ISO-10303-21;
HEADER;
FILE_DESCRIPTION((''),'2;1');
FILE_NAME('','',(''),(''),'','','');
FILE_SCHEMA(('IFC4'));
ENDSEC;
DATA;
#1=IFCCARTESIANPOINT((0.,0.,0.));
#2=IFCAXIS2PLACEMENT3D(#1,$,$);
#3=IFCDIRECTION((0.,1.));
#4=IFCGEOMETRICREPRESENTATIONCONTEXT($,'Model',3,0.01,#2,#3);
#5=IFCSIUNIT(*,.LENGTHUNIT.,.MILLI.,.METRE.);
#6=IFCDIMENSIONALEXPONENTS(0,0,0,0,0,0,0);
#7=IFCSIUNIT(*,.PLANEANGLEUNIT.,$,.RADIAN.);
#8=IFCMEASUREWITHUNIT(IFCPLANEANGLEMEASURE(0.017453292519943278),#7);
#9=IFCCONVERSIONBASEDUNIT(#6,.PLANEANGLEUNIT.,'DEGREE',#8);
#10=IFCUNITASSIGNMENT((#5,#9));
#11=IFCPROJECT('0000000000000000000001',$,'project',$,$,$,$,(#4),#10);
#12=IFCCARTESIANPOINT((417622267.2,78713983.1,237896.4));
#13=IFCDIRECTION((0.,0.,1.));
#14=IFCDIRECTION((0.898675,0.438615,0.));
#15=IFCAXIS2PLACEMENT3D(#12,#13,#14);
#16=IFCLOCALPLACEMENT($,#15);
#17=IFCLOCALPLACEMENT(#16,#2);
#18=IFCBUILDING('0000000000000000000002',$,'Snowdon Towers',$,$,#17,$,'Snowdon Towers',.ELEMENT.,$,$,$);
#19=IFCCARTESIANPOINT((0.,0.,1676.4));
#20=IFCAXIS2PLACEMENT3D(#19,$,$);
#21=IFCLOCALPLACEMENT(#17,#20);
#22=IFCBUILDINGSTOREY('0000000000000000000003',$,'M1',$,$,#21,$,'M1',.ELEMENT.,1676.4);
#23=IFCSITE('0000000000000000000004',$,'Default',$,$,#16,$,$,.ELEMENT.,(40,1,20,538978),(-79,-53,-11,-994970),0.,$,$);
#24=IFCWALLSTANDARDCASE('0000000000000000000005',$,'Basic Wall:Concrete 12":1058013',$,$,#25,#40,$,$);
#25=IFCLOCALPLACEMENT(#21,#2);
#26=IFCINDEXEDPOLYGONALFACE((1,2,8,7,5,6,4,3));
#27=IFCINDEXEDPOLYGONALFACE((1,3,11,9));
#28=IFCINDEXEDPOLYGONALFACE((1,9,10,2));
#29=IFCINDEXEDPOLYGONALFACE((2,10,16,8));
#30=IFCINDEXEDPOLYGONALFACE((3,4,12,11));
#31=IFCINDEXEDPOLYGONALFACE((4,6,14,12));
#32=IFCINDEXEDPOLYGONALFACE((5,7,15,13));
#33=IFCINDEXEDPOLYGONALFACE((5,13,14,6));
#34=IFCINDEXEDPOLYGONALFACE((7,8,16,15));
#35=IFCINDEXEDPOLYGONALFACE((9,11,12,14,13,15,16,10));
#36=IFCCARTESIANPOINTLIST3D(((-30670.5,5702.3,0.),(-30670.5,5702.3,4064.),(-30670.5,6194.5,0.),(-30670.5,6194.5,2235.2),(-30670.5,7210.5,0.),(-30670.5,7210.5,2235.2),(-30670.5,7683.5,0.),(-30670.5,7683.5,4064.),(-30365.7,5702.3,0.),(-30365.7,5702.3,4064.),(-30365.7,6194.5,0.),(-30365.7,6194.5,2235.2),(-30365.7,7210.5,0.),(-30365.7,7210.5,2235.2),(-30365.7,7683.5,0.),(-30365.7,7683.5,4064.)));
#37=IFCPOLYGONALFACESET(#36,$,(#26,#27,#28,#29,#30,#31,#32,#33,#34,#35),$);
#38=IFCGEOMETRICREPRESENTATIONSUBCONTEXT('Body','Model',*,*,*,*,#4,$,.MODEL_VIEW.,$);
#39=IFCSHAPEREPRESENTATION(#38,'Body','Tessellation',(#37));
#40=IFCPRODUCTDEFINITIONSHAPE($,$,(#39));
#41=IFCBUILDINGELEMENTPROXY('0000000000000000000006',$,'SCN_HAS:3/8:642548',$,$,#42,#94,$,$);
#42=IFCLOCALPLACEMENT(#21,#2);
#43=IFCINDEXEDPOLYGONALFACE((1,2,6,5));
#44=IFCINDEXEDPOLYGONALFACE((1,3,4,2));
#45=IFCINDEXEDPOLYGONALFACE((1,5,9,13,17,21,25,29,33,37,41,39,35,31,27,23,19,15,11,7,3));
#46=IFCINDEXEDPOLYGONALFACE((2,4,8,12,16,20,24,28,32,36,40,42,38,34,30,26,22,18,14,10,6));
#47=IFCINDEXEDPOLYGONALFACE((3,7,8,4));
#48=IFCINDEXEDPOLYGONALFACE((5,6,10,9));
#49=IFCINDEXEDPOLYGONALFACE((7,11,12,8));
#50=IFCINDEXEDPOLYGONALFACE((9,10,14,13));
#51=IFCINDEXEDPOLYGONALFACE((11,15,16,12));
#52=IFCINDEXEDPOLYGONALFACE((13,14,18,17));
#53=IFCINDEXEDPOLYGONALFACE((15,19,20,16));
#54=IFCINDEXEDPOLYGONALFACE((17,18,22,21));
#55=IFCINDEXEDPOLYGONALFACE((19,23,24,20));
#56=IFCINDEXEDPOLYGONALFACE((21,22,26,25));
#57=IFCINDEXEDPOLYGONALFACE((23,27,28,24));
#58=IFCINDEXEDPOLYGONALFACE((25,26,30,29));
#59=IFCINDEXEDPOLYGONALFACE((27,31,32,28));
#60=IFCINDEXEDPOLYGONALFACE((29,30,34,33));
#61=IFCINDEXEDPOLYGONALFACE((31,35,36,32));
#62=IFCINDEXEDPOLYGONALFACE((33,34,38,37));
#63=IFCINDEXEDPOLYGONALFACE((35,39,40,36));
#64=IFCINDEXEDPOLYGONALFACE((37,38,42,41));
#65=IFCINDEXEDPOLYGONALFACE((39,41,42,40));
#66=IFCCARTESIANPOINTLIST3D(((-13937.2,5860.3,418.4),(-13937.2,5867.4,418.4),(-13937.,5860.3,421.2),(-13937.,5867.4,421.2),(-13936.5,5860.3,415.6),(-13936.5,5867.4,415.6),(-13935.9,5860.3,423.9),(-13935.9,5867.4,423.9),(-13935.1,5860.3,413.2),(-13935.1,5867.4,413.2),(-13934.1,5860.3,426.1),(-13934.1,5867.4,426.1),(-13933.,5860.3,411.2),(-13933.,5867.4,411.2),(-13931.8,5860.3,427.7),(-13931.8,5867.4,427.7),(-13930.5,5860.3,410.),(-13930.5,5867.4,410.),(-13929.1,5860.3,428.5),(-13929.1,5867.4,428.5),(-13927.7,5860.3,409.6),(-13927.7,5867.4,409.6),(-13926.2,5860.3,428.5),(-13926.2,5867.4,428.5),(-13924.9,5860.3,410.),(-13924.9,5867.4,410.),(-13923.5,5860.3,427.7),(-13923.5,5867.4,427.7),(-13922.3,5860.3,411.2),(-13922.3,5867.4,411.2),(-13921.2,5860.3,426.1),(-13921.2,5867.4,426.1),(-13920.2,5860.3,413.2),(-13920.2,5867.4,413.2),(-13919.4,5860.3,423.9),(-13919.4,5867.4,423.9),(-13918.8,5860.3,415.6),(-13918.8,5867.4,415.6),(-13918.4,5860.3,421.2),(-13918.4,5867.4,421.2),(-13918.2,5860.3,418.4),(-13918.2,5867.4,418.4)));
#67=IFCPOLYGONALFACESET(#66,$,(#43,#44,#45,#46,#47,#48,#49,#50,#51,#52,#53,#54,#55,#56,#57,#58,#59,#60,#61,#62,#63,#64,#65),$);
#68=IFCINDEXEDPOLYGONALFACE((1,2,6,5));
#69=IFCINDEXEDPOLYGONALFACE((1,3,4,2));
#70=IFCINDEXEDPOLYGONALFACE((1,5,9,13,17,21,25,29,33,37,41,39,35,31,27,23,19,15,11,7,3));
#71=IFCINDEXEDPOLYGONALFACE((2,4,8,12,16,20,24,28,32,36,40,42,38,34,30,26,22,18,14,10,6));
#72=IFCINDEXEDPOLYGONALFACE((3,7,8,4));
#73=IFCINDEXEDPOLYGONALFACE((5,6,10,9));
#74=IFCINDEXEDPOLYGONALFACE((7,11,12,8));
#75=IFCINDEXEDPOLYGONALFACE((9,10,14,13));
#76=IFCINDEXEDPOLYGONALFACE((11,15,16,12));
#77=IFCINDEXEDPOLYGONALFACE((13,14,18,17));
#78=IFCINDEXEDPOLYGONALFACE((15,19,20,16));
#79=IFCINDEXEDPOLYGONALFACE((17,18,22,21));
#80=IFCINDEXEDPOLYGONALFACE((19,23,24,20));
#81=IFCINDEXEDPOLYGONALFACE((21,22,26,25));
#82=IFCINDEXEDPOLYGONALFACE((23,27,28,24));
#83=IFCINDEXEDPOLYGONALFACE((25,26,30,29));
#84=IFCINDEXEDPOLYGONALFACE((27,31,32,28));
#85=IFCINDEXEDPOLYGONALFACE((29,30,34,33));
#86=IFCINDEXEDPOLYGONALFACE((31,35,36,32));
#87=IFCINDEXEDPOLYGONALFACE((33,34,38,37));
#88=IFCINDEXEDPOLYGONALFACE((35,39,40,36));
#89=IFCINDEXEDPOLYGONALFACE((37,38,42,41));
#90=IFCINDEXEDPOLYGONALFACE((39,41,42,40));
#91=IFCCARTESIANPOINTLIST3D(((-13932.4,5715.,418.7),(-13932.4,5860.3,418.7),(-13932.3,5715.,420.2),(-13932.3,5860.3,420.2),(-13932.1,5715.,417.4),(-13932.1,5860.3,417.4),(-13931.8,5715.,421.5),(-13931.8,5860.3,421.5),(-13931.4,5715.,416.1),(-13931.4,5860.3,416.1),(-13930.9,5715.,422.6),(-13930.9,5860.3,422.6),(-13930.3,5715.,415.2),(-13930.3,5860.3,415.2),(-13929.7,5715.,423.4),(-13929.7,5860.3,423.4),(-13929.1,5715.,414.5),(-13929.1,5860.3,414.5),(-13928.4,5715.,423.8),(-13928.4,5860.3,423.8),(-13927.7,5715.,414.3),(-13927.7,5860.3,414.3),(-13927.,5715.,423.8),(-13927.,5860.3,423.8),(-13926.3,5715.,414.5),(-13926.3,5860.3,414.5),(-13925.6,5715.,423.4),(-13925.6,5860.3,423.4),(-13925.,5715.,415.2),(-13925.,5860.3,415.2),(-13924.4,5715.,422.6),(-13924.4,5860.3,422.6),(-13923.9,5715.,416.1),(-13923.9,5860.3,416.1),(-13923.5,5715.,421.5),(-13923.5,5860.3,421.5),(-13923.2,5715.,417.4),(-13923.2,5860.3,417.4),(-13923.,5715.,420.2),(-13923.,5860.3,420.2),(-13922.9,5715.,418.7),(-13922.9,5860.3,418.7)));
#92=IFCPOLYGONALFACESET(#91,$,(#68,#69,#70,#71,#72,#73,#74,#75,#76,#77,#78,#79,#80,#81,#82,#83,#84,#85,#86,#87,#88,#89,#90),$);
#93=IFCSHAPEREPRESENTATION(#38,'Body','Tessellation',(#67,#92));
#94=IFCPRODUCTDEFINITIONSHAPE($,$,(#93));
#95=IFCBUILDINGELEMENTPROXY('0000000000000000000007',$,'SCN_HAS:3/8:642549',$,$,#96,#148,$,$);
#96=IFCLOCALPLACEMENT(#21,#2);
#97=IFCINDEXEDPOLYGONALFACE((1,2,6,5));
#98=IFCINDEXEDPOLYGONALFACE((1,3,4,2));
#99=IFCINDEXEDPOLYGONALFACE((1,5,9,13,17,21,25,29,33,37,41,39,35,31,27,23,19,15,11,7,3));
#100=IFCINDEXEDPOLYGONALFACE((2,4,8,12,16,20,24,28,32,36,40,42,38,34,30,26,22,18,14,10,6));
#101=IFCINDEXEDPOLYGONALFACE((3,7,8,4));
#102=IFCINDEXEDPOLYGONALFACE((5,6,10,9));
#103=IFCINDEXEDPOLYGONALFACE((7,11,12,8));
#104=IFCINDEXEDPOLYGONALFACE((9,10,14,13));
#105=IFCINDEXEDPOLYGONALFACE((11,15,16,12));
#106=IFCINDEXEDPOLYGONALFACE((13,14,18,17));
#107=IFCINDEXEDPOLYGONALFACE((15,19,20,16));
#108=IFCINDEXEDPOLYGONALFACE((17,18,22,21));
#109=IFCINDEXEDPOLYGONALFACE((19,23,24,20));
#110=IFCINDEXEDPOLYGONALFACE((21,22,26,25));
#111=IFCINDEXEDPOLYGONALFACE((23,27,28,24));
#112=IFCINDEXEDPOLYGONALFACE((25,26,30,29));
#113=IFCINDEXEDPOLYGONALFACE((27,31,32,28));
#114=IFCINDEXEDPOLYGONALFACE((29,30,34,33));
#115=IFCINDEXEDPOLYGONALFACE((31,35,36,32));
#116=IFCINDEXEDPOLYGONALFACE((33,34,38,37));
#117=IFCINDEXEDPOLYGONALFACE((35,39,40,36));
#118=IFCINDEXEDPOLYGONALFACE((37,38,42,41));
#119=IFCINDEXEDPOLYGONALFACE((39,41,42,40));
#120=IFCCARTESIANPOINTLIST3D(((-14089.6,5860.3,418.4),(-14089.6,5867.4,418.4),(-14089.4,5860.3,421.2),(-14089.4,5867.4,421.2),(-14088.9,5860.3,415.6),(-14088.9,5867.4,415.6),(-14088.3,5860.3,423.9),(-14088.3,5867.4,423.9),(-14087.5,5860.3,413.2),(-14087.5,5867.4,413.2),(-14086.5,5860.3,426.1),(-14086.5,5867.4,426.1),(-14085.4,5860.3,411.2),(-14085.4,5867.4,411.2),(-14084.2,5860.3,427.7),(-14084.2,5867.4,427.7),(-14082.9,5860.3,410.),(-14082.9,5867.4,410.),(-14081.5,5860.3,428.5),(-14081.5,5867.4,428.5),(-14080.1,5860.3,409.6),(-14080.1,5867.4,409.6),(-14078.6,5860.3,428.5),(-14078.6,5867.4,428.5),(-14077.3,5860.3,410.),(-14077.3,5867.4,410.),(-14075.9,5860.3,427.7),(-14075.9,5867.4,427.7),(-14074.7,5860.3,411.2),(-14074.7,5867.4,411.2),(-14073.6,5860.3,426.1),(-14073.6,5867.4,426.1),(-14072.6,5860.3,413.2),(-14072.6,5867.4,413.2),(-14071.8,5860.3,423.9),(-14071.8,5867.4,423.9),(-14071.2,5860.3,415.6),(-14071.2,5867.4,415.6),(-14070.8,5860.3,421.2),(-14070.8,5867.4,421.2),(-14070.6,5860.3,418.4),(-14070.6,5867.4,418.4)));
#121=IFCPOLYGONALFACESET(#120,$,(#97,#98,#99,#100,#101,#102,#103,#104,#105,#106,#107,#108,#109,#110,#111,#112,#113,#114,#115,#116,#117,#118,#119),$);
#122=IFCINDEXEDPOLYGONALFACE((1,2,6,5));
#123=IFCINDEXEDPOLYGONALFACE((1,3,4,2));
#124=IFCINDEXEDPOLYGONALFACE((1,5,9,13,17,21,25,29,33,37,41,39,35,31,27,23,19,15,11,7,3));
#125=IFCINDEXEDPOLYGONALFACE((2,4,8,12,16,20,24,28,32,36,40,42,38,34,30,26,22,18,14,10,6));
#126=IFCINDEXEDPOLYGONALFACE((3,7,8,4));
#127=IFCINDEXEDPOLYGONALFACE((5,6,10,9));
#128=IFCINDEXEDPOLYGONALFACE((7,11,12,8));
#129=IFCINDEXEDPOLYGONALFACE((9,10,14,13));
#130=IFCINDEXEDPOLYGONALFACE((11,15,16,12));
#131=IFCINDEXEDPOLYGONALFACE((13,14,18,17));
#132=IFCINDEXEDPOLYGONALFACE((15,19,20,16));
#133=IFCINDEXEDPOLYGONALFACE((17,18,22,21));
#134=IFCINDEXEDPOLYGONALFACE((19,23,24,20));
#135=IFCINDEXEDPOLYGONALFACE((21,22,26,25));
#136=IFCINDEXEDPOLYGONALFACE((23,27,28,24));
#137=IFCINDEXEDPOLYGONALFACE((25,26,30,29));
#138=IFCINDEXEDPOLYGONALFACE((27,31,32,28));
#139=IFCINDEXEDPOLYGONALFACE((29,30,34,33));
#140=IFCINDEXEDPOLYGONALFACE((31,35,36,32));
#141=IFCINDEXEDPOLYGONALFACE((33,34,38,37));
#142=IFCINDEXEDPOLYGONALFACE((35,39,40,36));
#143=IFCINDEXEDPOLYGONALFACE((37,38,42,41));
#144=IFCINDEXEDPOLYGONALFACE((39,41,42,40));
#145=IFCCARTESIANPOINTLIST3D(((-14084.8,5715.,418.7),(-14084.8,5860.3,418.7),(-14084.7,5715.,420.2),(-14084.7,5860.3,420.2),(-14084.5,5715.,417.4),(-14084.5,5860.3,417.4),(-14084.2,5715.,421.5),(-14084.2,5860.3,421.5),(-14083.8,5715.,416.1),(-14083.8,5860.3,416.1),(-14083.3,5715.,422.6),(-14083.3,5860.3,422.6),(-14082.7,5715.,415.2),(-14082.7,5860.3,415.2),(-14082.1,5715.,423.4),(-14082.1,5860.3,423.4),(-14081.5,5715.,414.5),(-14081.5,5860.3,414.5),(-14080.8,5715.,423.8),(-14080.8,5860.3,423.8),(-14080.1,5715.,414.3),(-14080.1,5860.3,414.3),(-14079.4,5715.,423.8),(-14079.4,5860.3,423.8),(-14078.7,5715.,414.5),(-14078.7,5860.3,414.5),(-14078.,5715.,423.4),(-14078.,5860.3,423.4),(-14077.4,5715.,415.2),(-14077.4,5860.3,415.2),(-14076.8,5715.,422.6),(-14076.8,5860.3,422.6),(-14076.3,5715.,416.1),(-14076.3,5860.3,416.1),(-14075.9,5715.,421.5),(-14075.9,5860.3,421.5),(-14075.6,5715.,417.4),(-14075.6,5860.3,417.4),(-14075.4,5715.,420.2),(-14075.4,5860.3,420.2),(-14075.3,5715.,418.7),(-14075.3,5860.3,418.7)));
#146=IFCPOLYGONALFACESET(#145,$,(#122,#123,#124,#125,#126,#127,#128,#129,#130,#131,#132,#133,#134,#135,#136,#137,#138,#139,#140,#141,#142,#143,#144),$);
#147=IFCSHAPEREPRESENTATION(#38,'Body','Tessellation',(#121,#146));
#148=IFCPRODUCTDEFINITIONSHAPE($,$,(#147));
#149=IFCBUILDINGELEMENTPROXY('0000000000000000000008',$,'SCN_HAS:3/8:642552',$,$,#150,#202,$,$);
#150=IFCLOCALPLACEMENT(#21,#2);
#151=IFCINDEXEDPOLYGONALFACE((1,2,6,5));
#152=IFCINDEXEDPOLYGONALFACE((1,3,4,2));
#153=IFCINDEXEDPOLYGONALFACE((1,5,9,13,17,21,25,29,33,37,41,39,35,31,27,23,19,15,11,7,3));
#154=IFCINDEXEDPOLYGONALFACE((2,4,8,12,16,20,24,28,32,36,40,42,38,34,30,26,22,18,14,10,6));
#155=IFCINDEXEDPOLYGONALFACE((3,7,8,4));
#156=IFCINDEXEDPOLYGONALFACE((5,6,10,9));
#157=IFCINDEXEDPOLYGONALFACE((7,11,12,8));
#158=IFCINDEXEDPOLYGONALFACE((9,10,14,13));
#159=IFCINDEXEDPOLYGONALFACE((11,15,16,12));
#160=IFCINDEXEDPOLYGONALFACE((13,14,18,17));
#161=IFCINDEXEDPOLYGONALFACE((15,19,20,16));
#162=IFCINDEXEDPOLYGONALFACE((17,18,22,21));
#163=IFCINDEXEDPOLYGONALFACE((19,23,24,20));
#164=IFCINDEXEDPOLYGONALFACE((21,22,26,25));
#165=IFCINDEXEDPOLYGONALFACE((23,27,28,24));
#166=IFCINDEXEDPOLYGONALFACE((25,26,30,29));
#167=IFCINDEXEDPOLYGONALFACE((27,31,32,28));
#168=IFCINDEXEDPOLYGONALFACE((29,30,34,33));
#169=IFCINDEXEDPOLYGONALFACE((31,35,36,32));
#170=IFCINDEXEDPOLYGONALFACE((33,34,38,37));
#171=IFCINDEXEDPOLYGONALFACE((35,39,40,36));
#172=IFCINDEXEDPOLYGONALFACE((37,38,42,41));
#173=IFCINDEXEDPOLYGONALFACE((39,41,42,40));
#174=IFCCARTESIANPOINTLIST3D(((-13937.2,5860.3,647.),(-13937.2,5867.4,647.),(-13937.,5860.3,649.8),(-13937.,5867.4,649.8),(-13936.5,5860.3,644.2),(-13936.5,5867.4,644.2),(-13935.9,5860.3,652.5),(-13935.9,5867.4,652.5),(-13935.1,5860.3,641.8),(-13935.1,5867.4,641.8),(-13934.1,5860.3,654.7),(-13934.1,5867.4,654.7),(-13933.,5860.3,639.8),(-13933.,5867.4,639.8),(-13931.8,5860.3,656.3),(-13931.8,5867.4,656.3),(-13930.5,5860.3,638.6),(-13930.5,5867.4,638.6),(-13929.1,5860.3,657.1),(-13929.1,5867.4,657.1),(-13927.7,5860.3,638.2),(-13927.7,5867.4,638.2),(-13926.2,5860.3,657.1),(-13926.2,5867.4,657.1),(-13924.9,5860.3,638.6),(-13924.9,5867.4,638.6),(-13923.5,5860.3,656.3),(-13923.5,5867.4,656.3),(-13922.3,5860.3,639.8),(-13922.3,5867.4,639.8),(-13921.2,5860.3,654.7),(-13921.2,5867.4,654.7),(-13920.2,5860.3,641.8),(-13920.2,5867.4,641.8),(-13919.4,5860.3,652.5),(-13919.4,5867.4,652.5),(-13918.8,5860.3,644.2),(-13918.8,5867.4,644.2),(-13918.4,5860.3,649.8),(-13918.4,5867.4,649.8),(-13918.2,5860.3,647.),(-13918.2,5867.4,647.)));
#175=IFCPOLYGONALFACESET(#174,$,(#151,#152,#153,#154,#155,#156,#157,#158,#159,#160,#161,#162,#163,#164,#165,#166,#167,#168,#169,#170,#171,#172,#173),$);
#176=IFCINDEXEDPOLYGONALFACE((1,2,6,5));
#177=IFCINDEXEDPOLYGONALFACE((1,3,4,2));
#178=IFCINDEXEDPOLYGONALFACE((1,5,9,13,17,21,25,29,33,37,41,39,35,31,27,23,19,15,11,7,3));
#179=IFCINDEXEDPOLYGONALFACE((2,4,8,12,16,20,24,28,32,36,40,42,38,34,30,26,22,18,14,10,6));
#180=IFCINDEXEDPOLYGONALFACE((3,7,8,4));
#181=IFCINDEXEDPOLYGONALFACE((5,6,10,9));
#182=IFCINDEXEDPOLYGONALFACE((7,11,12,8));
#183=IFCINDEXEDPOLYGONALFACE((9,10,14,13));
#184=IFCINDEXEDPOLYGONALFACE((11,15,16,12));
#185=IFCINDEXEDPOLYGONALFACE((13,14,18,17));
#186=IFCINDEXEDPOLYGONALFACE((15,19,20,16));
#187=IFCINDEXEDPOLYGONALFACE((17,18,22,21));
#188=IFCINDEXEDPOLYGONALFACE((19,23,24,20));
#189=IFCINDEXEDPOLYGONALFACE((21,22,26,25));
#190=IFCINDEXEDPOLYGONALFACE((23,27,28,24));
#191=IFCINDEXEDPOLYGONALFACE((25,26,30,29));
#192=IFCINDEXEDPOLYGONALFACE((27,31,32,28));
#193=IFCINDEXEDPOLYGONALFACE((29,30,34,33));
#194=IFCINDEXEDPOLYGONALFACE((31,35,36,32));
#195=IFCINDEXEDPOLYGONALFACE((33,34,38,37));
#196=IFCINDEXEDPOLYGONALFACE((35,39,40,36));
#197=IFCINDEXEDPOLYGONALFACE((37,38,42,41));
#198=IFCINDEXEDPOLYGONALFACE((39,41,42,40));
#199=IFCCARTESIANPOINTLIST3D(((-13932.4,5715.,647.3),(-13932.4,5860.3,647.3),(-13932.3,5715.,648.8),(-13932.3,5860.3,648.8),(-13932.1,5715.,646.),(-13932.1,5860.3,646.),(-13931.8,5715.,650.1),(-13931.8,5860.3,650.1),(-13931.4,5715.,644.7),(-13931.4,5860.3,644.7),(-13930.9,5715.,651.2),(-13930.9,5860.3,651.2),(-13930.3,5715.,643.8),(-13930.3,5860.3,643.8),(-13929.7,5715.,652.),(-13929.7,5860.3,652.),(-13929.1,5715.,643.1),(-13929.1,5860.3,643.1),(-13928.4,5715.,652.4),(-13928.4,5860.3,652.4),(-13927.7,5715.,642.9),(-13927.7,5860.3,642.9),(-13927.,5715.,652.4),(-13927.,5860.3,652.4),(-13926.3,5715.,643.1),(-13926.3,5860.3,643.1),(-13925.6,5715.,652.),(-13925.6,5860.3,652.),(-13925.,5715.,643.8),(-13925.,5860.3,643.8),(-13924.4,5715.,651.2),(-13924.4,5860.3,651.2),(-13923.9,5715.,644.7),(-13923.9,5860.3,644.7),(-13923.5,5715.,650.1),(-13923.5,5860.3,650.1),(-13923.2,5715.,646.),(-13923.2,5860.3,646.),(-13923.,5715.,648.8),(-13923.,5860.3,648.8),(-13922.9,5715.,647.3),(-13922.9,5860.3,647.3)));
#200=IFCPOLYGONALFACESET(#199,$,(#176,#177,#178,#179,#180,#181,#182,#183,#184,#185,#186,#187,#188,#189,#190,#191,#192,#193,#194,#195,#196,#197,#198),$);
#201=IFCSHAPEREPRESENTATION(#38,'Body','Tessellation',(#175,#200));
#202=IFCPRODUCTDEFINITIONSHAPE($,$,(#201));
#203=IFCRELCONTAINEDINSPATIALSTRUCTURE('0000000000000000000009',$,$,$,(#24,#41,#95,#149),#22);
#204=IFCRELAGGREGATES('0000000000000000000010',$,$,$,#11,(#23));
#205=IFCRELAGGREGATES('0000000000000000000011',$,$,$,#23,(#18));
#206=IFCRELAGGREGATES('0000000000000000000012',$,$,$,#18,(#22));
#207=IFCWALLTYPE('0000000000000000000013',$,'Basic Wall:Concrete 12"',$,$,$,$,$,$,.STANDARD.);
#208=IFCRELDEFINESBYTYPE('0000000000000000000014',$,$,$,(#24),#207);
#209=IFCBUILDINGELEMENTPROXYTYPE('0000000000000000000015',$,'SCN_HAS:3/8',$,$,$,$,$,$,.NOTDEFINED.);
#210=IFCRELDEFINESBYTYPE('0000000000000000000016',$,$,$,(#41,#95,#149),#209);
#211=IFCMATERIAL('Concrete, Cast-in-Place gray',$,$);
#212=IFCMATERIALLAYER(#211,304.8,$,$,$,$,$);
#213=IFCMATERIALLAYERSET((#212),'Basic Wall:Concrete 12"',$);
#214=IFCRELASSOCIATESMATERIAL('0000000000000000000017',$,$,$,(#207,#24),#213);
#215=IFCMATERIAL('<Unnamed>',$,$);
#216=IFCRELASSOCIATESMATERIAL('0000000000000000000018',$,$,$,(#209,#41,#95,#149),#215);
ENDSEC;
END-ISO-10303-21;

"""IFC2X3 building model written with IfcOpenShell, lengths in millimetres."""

from ifc_helpers import new_model, entity, si_unit, converted_unit, direction, frame, frame_2d, origin, place, context, subcontext, project, spatial, rectangle, circle, extrude, source, transform, mapped, material, layer, layer_set, layer_usage, type_object, type_shapes, element, save


model = new_model("IFC2X3")

# Units and contexts
model_context = context("Model", 3, precision=0.01, world=origin(), true_north=direction((0.0, 1.0)))
body_context = subcontext(model_context, "Body", "Model", "MODEL_VIEW")
ifc_project = project(units=[si_unit("LENGTHUNIT", "METRE", prefix="MILLI"), converted_unit("PLANEANGLEUNIT", "DEGREE", entity("IfcPlaneAngleMeasure", 0.017453292519943278), si_unit("PLANEANGLEUNIT", "RADIAN"), dimensions=[0, 0, 0, 0, 0, 0, 0])], contexts=[model_context])

# Site, building, storey
site_placement = place(None, frame((417622267.2, 78713983.1, 237896.4), z_axis=(0.0, 0.0, 1.0), x_axis=(0.898675, 0.438615, 0.0)))
site = spatial("IfcSite", under=ifc_project, at=site_placement, Name="Default", CompositionType="ELEMENT", RefLatitude=(40, 1, 20, 538978), RefLongitude=(-79, -53, -11, -994970), RefElevation=0.0)
building_placement = place(site_placement, origin())
building = spatial("IfcBuilding", under=site, at=building_placement, Name="Snowdon Towers", LongName="Snowdon Towers", CompositionType="ELEMENT")
storey_placement = place(building_placement, frame((0.0, 0.0, 1676.4)))
storey = spatial("IfcBuildingStorey", under=building, at=storey_placement, Name="M1", LongName="M1", CompositionType="ELEMENT", Elevation=1676.4)

# Shared definitions
ifc_material_1 = material(Name="Concrete, Cast-in-Place gray")
ifc_layer_1 = layer(ifc_material_1, 304.8)
ifc_layer_set_1 = layer_set([ifc_layer_1], Name="Basic Wall:Concrete 12\"")
wall_type_1 = type_object("IfcWallType", Name="Basic Wall:Concrete 12\"", PredefinedType="STANDARD", material=ifc_layer_set_1)

# Wall, opening
ifc_layer_usage_1 = layer_usage(ifc_layer_set_1, "AXIS2", "POSITIVE", -152.4)
wall_1_placement = place(storey_placement, frame((-30518.1, 7683.5, 0.0), z_axis=(0.0, 0.0, 1.0), x_axis=(0.0, -1.0, 0.0)))
wall_1 = element("IfcWallStandardCase", 1, at=wall_1_placement, inside=storey, type_object=wall_type_1, material=ifc_layer_usage_1, Name="Basic Wall:Concrete 12\":1058013", context=body_context, shape_type="SweptSolid", body=[
    extrude(rectangle(XDim=1981.2, YDim=304.8, at=frame_2d((990.6, 0.0), x_axis=(-1.0, 0.0))), origin(), (0.0, 0.0, 1.0), 4064.0),
])
opening_placement = place(wall_1_placement, origin())
element("IfcOpeningElement", 2, at=opening_placement, cuts=wall_1, ObjectType="Opening", context=body_context, shape_type="SweptSolid", body=[
    extrude(rectangle(XDim=2235.2, YDim=1016.0, at=frame_2d((0.0, 0.0), x_axis=(0.0, 1.0))), frame((981.0, 152.4, 1117.6), z_axis=(0.0, -1.0, 0.0), x_axis=(1.0, 0.0, 0.0)), (0.0, 0.0, 1.0), 304.8),
])

# Building element proxies
ifc_material_2 = material(Name="<Unnamed>")
building_element_proxy_type = type_object("IfcBuildingElementProxyType", Name="SCN_HAS:3/8", PredefinedType="NOTDEFINED", material=ifc_material_2)
shared_shape_1 = source(origin(), body_context, "Body", "SweptSolid", [
    extrude(circle(Radius=9.5, at=frame_2d((0.0, 0.0), x_axis=(1.0, 0.0))), frame((0.0, 0.0, -152.4), z_axis=(0.0, 0.0, 1.0), x_axis=(0.0, -1.0, 0.0)), (0.0, 0.0, 1.0), 7.1),
    extrude(circle(Radius=4.8, at=frame_2d((0.0, 0.0), x_axis=(1.0, 0.0))), frame((0.0, 0.0, -145.3), z_axis=(0.0, 0.0, 1.0), x_axis=(0.0, -1.0, 0.0)), (0.0, 0.0, 1.0), 145.3),
])
type_shapes(building_element_proxy_type, [shared_shape_1])
for number, where, z_axis, x_axis, name in (
    (3, (-13927.7, 5715.0, 419.1), (0.0, -1.0, 0.0), (1.0, 0.0, 0.0), "SCN_HAS:3/8:642548"),
    (4, (-14080.1, 5715.0, 419.1), (0.0, -1.0, 0.0), (1.0, 0.0, 0.0), "SCN_HAS:3/8:642549"),
    (5, (-13927.7, 5715.0, 647.7), (0.0, -1.0, 0.0), (1.0, 0.0, 0.0), "SCN_HAS:3/8:642552"),
):
    element("IfcBuildingElementProxy", number, at=place(storey_placement, frame(where, z_axis=z_axis, x_axis=x_axis)), inside=storey, type_object=building_element_proxy_type, material=ifc_material_2, Name=name, context=body_context, shape_type="MappedRepresentation", body=[
        mapped(shared_shape_1, transform((0.0, 0.0, 0.0), scale=1.0)),
    ])

save(model, "model.ifc")
